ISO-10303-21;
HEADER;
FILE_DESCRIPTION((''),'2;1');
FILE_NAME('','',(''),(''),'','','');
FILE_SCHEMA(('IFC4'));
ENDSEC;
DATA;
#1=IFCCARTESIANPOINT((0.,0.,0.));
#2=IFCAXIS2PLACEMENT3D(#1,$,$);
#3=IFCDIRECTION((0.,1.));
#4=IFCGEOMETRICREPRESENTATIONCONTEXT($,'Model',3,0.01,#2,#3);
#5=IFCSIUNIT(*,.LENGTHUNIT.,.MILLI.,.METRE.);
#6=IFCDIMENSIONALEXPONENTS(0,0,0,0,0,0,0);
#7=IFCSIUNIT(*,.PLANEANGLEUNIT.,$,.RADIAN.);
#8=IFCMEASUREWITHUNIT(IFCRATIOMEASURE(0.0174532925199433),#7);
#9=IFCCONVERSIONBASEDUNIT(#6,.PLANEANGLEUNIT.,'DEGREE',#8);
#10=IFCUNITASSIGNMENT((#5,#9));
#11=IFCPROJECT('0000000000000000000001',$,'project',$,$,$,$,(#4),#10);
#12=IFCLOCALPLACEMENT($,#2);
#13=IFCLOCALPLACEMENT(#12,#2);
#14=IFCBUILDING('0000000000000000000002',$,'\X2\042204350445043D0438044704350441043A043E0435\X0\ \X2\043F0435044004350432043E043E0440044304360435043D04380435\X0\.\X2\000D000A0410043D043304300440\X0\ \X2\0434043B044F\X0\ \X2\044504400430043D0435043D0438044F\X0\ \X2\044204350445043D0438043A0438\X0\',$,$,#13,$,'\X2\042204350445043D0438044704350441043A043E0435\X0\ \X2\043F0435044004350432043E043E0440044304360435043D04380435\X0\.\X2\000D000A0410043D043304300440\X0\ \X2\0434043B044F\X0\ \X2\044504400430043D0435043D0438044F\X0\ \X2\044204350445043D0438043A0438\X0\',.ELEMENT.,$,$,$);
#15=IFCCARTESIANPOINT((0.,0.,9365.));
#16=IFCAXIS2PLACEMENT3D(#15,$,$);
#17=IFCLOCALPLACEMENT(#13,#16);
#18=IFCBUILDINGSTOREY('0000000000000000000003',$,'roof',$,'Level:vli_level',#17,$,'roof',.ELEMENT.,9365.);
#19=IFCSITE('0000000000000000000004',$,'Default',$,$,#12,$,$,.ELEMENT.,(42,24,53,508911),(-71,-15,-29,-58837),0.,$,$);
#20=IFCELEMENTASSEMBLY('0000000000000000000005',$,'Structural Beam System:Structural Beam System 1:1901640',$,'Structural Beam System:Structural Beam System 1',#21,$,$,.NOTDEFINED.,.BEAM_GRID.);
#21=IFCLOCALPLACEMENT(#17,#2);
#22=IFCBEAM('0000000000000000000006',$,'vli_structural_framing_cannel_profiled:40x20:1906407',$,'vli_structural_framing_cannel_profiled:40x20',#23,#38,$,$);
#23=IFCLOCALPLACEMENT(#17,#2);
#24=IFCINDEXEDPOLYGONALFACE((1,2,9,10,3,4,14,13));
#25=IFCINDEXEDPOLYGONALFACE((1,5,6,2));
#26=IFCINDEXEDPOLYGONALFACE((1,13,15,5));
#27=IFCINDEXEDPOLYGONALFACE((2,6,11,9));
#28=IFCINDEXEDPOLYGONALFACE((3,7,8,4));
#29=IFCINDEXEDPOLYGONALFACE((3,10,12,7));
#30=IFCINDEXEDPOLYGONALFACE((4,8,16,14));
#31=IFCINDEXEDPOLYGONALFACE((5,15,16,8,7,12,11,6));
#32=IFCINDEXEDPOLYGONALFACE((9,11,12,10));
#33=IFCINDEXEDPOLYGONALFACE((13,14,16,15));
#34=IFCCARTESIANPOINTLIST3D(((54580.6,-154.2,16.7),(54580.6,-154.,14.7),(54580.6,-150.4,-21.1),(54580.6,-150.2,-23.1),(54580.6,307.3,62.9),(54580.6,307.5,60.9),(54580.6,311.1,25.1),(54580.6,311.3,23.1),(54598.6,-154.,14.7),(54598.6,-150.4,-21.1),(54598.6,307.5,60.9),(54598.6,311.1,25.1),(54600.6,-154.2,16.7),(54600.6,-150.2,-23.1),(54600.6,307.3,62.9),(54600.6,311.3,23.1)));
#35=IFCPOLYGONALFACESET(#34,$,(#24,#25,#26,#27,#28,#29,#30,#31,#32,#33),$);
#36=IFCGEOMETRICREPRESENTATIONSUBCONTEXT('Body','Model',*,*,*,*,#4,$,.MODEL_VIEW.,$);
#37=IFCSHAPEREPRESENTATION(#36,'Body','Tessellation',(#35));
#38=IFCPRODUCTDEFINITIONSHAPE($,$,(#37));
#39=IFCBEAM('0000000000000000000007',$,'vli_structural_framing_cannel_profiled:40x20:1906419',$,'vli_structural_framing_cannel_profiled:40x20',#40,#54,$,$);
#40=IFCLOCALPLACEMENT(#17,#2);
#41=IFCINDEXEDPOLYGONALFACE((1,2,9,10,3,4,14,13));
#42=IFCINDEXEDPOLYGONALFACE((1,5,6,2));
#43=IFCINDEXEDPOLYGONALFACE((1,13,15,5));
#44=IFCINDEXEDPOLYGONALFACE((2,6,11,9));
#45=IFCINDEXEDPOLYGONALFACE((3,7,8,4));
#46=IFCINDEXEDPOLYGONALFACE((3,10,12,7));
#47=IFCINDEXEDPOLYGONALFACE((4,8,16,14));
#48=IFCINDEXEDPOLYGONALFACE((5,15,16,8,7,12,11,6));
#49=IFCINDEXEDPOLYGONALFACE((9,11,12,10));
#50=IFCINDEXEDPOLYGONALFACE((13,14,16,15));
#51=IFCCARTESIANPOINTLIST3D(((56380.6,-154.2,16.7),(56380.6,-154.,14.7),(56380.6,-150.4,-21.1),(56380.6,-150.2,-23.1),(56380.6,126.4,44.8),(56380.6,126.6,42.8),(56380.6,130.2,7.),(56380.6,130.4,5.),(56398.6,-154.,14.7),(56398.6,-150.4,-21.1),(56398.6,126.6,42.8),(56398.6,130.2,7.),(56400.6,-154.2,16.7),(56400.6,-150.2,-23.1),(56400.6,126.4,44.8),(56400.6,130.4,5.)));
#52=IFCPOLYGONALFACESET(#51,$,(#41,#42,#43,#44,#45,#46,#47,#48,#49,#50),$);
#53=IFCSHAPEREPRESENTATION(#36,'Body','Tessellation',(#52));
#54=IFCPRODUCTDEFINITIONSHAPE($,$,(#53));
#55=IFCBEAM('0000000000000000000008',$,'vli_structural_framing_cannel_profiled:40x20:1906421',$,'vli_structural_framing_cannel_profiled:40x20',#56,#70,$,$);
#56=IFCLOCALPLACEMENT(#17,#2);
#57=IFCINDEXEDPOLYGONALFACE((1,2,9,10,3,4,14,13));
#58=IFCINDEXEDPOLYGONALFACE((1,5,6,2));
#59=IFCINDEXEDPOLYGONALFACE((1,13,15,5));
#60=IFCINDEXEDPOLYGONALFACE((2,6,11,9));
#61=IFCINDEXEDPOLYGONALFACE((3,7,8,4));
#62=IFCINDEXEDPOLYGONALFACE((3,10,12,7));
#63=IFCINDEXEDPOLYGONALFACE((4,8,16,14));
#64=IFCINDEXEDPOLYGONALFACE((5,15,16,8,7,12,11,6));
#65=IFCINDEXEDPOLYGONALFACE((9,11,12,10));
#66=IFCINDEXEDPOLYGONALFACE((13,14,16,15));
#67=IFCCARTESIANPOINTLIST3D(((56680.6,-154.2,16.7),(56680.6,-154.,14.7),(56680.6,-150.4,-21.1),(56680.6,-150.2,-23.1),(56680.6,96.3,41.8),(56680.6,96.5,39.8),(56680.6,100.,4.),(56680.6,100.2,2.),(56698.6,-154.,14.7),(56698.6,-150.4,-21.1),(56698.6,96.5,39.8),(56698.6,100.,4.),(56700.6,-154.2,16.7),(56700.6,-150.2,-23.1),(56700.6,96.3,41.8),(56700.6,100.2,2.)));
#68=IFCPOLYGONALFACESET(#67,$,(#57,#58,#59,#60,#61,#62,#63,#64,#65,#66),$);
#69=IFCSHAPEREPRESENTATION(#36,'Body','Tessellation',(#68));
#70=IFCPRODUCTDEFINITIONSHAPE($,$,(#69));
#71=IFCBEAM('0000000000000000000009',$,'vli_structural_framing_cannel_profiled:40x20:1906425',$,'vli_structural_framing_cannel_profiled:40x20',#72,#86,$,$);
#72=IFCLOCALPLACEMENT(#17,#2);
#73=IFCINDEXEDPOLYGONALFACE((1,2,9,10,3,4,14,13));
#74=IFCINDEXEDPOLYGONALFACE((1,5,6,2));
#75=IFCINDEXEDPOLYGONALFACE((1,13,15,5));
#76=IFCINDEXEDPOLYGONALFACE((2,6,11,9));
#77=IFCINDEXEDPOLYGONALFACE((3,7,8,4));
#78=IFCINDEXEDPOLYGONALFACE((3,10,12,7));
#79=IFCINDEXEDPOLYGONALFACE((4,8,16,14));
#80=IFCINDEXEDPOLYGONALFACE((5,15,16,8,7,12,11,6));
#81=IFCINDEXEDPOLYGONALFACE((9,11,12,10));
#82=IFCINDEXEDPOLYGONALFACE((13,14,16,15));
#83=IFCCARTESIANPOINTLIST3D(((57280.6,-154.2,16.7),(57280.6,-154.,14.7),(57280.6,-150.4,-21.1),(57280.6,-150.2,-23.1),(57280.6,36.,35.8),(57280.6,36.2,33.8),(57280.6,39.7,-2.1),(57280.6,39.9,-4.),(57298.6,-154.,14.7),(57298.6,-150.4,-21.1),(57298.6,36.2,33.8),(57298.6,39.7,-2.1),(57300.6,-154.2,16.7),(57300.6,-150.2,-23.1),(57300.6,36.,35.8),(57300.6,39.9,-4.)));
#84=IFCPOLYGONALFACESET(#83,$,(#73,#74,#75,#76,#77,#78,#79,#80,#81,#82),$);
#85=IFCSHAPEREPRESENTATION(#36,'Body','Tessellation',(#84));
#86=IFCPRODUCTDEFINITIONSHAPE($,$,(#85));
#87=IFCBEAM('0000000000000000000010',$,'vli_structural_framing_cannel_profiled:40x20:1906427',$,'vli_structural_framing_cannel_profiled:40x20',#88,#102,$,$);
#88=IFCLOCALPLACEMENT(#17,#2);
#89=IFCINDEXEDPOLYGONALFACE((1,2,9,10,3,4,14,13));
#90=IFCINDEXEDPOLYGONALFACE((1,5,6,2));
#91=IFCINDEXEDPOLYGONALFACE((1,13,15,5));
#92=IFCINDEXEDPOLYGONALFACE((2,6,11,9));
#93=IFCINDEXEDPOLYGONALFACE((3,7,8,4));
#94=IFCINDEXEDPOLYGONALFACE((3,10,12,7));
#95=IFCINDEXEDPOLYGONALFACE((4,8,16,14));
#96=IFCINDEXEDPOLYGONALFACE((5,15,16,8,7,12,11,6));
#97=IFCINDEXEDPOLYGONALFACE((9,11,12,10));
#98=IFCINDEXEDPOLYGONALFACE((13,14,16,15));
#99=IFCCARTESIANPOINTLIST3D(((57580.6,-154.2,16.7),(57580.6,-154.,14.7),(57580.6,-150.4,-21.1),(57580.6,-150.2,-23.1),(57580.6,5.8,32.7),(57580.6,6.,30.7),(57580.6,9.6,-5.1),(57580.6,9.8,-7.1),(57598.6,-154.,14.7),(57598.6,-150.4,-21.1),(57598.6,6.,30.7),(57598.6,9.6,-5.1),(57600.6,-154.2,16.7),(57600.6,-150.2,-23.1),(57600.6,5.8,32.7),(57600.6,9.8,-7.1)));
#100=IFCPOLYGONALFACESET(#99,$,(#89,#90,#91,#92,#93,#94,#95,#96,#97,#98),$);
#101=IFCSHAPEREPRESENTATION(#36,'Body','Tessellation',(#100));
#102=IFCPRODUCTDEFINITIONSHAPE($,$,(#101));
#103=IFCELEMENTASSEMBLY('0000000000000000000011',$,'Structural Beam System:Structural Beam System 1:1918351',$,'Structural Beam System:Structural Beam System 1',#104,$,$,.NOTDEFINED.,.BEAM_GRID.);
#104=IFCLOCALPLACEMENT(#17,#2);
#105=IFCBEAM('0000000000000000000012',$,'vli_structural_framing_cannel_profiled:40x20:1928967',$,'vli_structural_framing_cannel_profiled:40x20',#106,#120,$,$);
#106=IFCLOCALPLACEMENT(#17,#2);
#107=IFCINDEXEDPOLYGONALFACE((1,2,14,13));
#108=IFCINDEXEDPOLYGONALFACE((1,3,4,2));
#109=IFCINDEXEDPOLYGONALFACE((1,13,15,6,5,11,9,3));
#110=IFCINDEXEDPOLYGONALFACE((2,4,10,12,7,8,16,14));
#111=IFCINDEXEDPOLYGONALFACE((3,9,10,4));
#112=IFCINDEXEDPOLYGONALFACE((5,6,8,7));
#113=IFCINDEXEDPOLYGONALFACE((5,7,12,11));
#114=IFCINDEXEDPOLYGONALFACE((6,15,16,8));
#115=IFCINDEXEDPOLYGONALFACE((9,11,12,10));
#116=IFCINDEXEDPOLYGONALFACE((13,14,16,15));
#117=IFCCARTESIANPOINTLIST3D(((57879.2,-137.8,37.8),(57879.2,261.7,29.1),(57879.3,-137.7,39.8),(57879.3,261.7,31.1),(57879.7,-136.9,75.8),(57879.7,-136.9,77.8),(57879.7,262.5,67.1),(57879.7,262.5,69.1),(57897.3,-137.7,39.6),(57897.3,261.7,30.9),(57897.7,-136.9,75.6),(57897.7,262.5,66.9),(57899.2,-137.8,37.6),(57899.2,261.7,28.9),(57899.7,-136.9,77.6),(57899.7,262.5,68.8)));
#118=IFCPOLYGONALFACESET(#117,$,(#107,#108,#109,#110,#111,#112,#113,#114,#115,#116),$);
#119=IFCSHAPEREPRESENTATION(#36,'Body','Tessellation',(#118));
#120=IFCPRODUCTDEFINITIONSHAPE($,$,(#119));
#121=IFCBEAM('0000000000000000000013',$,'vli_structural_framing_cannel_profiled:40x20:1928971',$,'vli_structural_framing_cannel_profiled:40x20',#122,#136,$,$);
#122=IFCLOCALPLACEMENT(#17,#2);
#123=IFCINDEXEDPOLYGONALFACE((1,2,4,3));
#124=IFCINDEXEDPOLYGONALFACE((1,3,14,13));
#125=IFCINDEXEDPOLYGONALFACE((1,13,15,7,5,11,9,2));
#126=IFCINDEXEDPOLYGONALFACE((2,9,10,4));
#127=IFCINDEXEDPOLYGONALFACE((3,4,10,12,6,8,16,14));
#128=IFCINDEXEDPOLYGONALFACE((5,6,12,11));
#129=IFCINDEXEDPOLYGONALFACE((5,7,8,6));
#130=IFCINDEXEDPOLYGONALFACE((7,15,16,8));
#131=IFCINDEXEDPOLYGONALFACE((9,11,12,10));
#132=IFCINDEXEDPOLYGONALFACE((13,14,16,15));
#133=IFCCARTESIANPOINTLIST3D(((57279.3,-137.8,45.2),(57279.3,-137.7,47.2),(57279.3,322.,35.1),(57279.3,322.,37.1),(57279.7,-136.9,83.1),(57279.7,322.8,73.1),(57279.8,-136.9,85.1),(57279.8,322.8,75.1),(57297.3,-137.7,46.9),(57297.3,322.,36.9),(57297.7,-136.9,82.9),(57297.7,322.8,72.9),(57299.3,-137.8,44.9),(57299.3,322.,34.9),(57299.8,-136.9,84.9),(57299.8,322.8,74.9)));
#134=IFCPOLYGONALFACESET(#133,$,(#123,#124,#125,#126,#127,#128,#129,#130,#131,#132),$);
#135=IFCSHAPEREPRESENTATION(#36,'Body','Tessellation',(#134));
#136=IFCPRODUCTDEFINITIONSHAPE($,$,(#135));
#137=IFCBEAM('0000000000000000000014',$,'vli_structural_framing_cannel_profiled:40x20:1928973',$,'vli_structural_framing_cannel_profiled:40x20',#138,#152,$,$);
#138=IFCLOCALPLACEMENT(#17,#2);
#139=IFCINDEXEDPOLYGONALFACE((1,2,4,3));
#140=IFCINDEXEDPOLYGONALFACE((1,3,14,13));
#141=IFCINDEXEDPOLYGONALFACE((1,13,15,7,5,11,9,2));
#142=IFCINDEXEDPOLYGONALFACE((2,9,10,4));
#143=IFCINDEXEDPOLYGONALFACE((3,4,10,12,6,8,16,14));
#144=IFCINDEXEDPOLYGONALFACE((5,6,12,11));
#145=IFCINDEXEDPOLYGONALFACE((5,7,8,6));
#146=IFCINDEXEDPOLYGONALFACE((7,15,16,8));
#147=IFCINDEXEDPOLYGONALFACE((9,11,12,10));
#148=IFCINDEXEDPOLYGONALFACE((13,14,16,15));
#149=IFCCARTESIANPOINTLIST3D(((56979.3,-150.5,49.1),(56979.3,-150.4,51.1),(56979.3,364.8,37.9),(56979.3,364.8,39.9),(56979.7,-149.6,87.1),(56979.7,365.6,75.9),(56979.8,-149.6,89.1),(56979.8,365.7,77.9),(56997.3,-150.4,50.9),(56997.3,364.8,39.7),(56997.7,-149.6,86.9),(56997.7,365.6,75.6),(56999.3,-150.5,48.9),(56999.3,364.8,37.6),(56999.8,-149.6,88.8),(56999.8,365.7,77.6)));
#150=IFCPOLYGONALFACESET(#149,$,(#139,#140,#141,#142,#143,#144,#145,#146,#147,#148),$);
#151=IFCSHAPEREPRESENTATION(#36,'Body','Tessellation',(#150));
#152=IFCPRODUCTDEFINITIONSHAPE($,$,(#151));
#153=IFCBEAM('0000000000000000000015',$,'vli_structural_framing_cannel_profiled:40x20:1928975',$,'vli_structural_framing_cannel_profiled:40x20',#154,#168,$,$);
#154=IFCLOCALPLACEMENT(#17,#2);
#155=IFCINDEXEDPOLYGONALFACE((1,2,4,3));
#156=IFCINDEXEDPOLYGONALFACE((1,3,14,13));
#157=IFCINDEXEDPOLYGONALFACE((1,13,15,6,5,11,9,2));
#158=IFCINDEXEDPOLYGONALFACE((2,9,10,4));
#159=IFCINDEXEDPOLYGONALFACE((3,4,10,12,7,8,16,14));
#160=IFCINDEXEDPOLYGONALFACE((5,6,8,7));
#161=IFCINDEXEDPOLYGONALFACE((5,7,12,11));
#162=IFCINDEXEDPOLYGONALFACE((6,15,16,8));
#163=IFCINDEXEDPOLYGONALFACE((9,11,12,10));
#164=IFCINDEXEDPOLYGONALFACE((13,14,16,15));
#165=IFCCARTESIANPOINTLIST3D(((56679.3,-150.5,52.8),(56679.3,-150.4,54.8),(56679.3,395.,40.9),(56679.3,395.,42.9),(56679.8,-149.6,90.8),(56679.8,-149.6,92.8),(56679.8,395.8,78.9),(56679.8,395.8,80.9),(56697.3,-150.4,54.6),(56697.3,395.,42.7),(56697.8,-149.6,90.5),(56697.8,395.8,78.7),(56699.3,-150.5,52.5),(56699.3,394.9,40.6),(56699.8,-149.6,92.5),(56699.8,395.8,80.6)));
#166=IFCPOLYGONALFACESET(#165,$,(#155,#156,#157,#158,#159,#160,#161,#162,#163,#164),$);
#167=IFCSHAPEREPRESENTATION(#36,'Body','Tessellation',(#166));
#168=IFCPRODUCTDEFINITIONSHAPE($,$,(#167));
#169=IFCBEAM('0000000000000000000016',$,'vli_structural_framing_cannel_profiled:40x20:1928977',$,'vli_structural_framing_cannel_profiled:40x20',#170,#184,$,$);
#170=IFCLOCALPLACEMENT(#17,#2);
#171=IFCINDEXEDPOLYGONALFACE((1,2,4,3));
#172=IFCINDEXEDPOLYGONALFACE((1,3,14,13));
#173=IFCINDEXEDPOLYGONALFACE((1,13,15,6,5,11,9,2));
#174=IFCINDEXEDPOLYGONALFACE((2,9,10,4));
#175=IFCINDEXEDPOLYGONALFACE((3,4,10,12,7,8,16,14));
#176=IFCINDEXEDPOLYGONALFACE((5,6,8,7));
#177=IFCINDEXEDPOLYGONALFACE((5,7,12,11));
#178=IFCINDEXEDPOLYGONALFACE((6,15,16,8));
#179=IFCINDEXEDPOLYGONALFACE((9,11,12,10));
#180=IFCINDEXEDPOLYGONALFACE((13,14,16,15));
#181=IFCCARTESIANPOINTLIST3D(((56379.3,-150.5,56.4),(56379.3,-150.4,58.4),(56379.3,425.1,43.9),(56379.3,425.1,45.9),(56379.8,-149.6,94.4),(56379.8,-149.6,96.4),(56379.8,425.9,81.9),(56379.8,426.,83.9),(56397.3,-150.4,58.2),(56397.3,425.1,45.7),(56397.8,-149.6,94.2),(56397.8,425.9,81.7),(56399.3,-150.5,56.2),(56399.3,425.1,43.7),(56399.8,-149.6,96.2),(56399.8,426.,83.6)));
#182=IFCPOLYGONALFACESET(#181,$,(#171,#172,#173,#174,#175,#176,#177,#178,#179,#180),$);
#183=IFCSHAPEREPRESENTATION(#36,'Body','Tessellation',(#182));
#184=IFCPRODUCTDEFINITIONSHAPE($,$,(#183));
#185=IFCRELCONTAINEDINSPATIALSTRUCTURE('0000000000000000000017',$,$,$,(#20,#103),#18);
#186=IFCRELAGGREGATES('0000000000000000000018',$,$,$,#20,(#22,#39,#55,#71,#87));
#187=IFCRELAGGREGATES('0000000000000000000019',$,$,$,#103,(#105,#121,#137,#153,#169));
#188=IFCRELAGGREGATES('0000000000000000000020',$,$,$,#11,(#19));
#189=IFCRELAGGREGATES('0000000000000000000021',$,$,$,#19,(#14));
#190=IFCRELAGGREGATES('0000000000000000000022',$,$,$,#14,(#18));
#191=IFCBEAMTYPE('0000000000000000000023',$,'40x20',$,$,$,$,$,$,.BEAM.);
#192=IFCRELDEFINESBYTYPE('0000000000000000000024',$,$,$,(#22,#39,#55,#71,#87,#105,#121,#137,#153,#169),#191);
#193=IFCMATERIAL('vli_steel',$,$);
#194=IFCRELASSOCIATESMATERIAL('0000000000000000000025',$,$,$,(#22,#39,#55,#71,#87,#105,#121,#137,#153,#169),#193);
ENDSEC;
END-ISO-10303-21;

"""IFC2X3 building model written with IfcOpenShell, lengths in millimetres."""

from ifc_helpers import new_model, entity, si_unit, converted_unit, direction, frame, origin, place, context, subcontext, project, spatial, polyline, outline, extrude, material, type_object, element, aggregate, save


model = new_model("IFC2X3")

# Units and contexts
model_context = context("Model", 3, precision=0.01, world=origin(), true_north=direction((0.0, 1.0)))
body_context = subcontext(model_context, "Body", "Model", "MODEL_VIEW")
ifc_project = project(units=[si_unit("LENGTHUNIT", "METRE", prefix="MILLI"), converted_unit("PLANEANGLEUNIT", "DEGREE", entity("IfcRatioMeasure", 0.0174532925199433), si_unit("PLANEANGLEUNIT", "RADIAN"), dimensions=[0, 0, 0, 0, 0, 0, 0])], contexts=[model_context])

# Site, building, storey
site_placement = place(None, origin())
site = spatial("IfcSite", under=ifc_project, at=site_placement, Name="Default", CompositionType="ELEMENT", RefLatitude=(42, 24, 53, 508911), RefLongitude=(-71, -15, -29, -58837), RefElevation=0.0)
building_placement = place(site_placement, origin())
building = spatial("IfcBuilding", under=site, at=building_placement, Name="Техническое перевооружение.\r\nАнгар для хранения техники", LongName="Техническое перевооружение.\r\nАнгар для хранения техники", CompositionType="ELEMENT")
storey_placement = place(building_placement, frame((0.0, 0.0, 9365.0)))
storey = spatial("IfcBuildingStorey", under=building, at=storey_placement, Name="roof", ObjectType="Level:vli_level", LongName="roof", CompositionType="ELEMENT", Elevation=9365.0)

# Element assemblies, beams
assembly_1_placement = place(storey_placement, origin())
assembly_1 = element("IfcElementAssembly", 1, at=assembly_1_placement, inside=storey, Name="Structural Beam System:Structural Beam System 1:1901640", ObjectType="Structural Beam System:Structural Beam System 1", AssemblyPlace="NOTDEFINED", PredefinedType="BEAM_GRID")
ifc_material = material(Name="vli_steel")
beam_type = type_object("IfcBeamType", Name="40x20", PredefinedType="BEAM")
beam_1_placement = place(assembly_1_placement, frame((54600.0, 311.3, 23.1), z_axis=(0.0, -0.099504, 0.995037), x_axis=(0.0, -0.995037, -0.099504)))
beam_1 = element("IfcBeam", 2, at=beam_1_placement, type_object=beam_type, material=ifc_material, Name="vli_structural_framing_cannel_profiled:40x20:1906407", ObjectType="vli_structural_framing_cannel_profiled:40x20", context=body_context, shape_type="SweptSolid", body=[
    extrude(outline(polyline([(-20.0, -9.5), (-18.0, -9.5), (-18.0, 8.5), (18.0, 8.5), (18.0, -9.5), (20.0, -9.5), (20.0, 10.5), (-20.0, 10.5), (-20.0, -9.5)])), frame((0.0, -9.9, 20.0), z_axis=(1.0, 0.0, 0.0), x_axis=(0.0, 0.0, -1.0)), (0.0, 0.0, 1.0), 463.8),
])
beam_2_placement = place(assembly_1_placement, frame((56400.0, 130.4, 5.0), z_axis=(0.0, -0.099504, 0.995037), x_axis=(0.0, -0.995037, -0.099504)))
beam_2 = element("IfcBeam", 3, at=beam_2_placement, type_object=beam_type, material=ifc_material, Name="vli_structural_framing_cannel_profiled:40x20:1906419", ObjectType="vli_structural_framing_cannel_profiled:40x20", context=body_context, shape_type="SweptSolid", body=[
    extrude(outline(polyline([(-20.0, -9.5), (-18.0, -9.5), (-18.0, 8.5), (18.0, 8.5), (18.0, -9.5), (20.0, -9.5), (20.0, 10.5), (-20.0, 10.5), (-20.0, -9.5)])), frame((0.0, -9.9, 20.0), z_axis=(1.0, 0.0, 0.0), x_axis=(0.0, 0.0, -1.0)), (0.0, 0.0, 1.0), 282.0),
])
beam_3_placement = place(assembly_1_placement, frame((56700.0, 100.2, 2.0), z_axis=(0.0, -0.099504, 0.995037), x_axis=(0.0, -0.995037, -0.099504)))
beam_3 = element("IfcBeam", 4, at=beam_3_placement, type_object=beam_type, material=ifc_material, Name="vli_structural_framing_cannel_profiled:40x20:1906421", ObjectType="vli_structural_framing_cannel_profiled:40x20", context=body_context, shape_type="SweptSolid", body=[
    extrude(outline(polyline([(-20.0, -9.5), (-18.0, -9.5), (-18.0, 8.5), (18.0, 8.5), (18.0, -9.5), (20.0, -9.5), (20.0, 10.5), (-20.0, 10.5), (-20.0, -9.5)])), frame((0.0, -9.9, 20.0), z_axis=(1.0, 0.0, 0.0), x_axis=(0.0, 0.0, -1.0)), (0.0, 0.0, 1.0), 251.7),
])
beam_4_placement = place(assembly_1_placement, frame((57300.0, 39.9, -4.0), z_axis=(0.0, -0.099504, 0.995037), x_axis=(0.0, -0.995037, -0.099504)))
beam_4 = element("IfcBeam", 5, at=beam_4_placement, type_object=beam_type, material=ifc_material, Name="vli_structural_framing_cannel_profiled:40x20:1906425", ObjectType="vli_structural_framing_cannel_profiled:40x20", context=body_context, shape_type="SweptSolid", body=[
    extrude(outline(polyline([(-20.0, -9.5), (-18.0, -9.5), (-18.0, 8.5), (18.0, 8.5), (18.0, -9.5), (20.0, -9.5), (20.0, 10.5), (-20.0, 10.5), (-20.0, -9.5)])), frame((0.0, -9.9, 20.0), z_axis=(1.0, 0.0, 0.0), x_axis=(0.0, 0.0, -1.0)), (0.0, 0.0, 1.0), 191.1),
])
beam_5_placement = place(assembly_1_placement, frame((57600.0, 9.8, -7.1), z_axis=(0.0, -0.099504, 0.995037), x_axis=(0.0, -0.995037, -0.099504)))
beam_5 = element("IfcBeam", 6, at=beam_5_placement, type_object=beam_type, material=ifc_material, Name="vli_structural_framing_cannel_profiled:40x20:1906427", ObjectType="vli_structural_framing_cannel_profiled:40x20", context=body_context, shape_type="SweptSolid", body=[
    extrude(outline(polyline([(-20.0, -9.5), (-18.0, -9.5), (-18.0, 8.5), (18.0, 8.5), (18.0, -9.5), (20.0, -9.5), (20.0, 10.5), (-20.0, 10.5), (-20.0, -9.5)])), frame((0.0, -9.9, 20.0), z_axis=(1.0, 0.0, 0.0), x_axis=(0.0, 0.0, -1.0)), (0.0, 0.0, 1.0), 160.8),
])
aggregate(assembly_1, [beam_1, beam_2, beam_3, beam_4, beam_5])
assembly_2_placement = place(storey_placement, origin())
assembly_2 = element("IfcElementAssembly", 7, at=assembly_2_placement, inside=storey, Name="Structural Beam System:Structural Beam System 1:1918351", ObjectType="Structural Beam System:Structural Beam System 1", AssemblyPlace="NOTDEFINED", PredefinedType="BEAM_GRID")
beam_6_placement = place(assembly_2_placement, frame((57899.1, 275.9, 68.6), z_axis=(0.0, 0.02179, 0.999763), x_axis=(0.0, -0.999763, 0.02179)))
beam_6 = element("IfcBeam", 8, at=beam_6_placement, type_object=beam_type, material=ifc_material, Name="vli_structural_framing_cannel_profiled:40x20:1928967", ObjectType="vli_structural_framing_cannel_profiled:40x20", context=body_context, shape_type="SweptSolid", body=[
    extrude(outline(polyline([(-10.5, -20.0), (9.5, -20.0), (9.5, -18.0), (-8.5, -18.0), (-8.5, 18.0), (9.5, 18.0), (9.5, 20.0), (-10.5, 20.0), (-10.5, -20.0)])), frame((13.4, -10.1, -19.9), z_axis=(1.0, 0.0, 0.0), x_axis=(0.0, -0.999925, 0.012243)), (0.0, 0.0, 1.0), 399.5),
])
beam_7_placement = place(assembly_2_placement, frame((57299.2, 336.2, 74.6), z_axis=(0.0, 0.02179, 0.999763), x_axis=(0.0, -0.999763, 0.02179)))
beam_7 = element("IfcBeam", 9, at=beam_7_placement, type_object=beam_type, material=ifc_material, Name="vli_structural_framing_cannel_profiled:40x20:1928971", ObjectType="vli_structural_framing_cannel_profiled:40x20", context=body_context, shape_type="SweptSolid", body=[
    extrude(outline(polyline([(-10.5, -20.0), (9.5, -20.0), (9.5, -18.0), (-8.5, -18.0), (-8.5, 18.0), (9.5, 18.0), (9.5, 20.0), (-10.5, 20.0), (-10.5, -20.0)])), frame((13.4, -10.1, -19.9), z_axis=(1.0, 0.0, 0.0), x_axis=(0.0, -0.999925, 0.012243)), (0.0, 0.0, 1.0), 459.8),
])
beam_8_placement = place(assembly_2_placement, frame((56999.2, 366.3, 77.6), z_axis=(0.0, 0.02179, 0.999763), x_axis=(0.0, -0.999763, 0.02179)))
beam_8 = element("IfcBeam", 10, at=beam_8_placement, type_object=beam_type, material=ifc_material, Name="vli_structural_framing_cannel_profiled:40x20:1928973", ObjectType="vli_structural_framing_cannel_profiled:40x20", context=body_context, shape_type="SweptSolid", body=[
    extrude(outline(polyline([(-10.5, -20.0), (9.5, -20.0), (9.5, -18.0), (-8.5, -18.0), (-8.5, 18.0), (9.5, 18.0), (9.5, 20.0), (-10.5, 20.0), (-10.5, -20.0)])), frame((0.7, -10.1, -19.9), z_axis=(1.0, 0.0, 0.0), x_axis=(0.0, -0.999925, 0.012243)), (0.0, 0.0, 1.0), 515.4),
])
beam_9_placement = place(assembly_2_placement, frame((56699.2, 396.5, 80.6), z_axis=(0.0, 0.02179, 0.999763), x_axis=(0.0, -0.999763, 0.02179)))
beam_9 = element("IfcBeam", 11, at=beam_9_placement, type_object=beam_type, material=ifc_material, Name="vli_structural_framing_cannel_profiled:40x20:1928975", ObjectType="vli_structural_framing_cannel_profiled:40x20", context=body_context, shape_type="SweptSolid", body=[
    extrude(outline(polyline([(-10.5, -20.0), (9.5, -20.0), (9.5, -18.0), (-8.5, -18.0), (-8.5, 18.0), (9.5, 18.0), (9.5, 20.0), (-10.5, 20.0), (-10.5, -20.0)])), frame((0.7, -10.1, -19.9), z_axis=(1.0, 0.0, 0.0), x_axis=(0.0, -0.999925, 0.012243)), (0.0, 0.0, 1.0), 545.5),
])
beam_10_placement = place(assembly_2_placement, frame((56399.2, 426.6, 83.6), z_axis=(0.0, 0.02179, 0.999763), x_axis=(0.0, -0.999763, 0.02179)))
beam_10 = element("IfcBeam", 12, at=beam_10_placement, type_object=beam_type, material=ifc_material, Name="vli_structural_framing_cannel_profiled:40x20:1928977", ObjectType="vli_structural_framing_cannel_profiled:40x20", context=body_context, shape_type="SweptSolid", body=[
    extrude(outline(polyline([(-10.5, -20.0), (9.5, -20.0), (9.5, -18.0), (-8.5, -18.0), (-8.5, 18.0), (9.5, 18.0), (9.5, 20.0), (-10.5, 20.0), (-10.5, -20.0)])), frame((0.7, -10.1, -19.9), z_axis=(1.0, 0.0, 0.0), x_axis=(0.0, -0.999925, 0.012243)), (0.0, 0.0, 1.0), 575.7),
])
aggregate(assembly_2, [beam_6, beam_7, beam_8, beam_9, beam_10])

save(model, "model.ifc")
